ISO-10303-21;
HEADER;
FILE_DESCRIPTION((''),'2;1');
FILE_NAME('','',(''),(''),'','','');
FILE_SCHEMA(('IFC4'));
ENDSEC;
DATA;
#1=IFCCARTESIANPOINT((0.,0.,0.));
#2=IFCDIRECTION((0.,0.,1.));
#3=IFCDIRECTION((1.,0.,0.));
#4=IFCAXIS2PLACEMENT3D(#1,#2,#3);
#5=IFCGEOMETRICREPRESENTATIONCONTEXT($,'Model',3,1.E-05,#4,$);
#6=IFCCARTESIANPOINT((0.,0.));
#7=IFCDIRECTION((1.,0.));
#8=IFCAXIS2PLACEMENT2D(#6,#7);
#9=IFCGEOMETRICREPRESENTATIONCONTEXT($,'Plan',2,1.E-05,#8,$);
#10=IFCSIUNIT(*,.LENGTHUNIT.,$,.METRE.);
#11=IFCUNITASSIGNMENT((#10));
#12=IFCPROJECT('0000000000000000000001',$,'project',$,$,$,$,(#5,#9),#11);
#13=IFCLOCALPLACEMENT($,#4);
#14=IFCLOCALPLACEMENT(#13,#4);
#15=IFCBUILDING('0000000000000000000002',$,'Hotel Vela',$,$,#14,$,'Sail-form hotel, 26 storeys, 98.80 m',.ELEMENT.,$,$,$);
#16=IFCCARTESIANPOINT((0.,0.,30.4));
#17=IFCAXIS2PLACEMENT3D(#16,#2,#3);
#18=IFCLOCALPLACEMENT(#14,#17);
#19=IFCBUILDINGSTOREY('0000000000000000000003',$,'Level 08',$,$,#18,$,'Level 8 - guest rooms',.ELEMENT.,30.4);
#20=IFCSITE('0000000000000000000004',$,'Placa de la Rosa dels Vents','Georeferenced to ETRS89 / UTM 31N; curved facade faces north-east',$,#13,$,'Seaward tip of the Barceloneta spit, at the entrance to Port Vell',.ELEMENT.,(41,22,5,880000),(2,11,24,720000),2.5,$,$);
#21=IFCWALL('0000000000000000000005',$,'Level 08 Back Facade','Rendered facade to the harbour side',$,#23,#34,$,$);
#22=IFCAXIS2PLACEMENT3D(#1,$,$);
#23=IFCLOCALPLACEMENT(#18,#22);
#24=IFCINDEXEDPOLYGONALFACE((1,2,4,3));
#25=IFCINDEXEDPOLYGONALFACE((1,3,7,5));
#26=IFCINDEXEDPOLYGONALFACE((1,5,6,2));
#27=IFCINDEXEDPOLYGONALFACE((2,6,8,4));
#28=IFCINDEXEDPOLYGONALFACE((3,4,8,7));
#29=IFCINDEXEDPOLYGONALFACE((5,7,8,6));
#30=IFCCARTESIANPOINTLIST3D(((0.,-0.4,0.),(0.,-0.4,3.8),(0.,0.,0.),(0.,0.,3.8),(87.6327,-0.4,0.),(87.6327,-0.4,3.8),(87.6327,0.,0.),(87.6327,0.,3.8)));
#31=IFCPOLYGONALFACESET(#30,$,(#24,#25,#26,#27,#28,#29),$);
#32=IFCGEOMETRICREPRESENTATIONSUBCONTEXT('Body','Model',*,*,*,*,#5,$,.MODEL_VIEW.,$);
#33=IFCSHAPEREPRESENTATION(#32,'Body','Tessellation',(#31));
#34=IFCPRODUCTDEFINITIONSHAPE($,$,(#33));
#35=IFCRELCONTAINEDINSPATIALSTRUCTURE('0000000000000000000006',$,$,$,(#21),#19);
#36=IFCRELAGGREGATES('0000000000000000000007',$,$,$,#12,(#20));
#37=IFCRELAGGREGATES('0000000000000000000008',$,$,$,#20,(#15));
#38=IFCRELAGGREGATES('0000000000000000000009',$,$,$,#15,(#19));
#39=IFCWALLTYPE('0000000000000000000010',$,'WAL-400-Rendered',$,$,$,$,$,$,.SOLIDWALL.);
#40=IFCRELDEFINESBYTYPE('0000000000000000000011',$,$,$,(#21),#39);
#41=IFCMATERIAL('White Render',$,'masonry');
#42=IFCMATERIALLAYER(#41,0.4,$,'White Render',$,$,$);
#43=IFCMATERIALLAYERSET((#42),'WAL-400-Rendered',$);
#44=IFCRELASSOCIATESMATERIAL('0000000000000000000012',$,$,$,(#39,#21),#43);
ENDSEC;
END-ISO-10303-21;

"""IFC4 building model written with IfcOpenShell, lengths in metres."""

from ifc_helpers import new_model, si_unit, frame, origin_with_axes, origin_2d_with_axis, place, context, subcontext, project, spatial, line, indexed_curve, outline, extrude, material, layer, layer_set, layer_usage, type_object, element, save


model = new_model("IFC4")

# Units and contexts
model_context = context("Model", 3, precision=1e-05, world=origin_with_axes())
plan_context = context("Plan", 2, precision=1e-05, world=origin_2d_with_axis())
body_context = subcontext(model_context, "Body", "Model", "MODEL_VIEW")
ifc_project = project(units=[si_unit("LENGTHUNIT", "METRE")], contexts=[model_context, plan_context])

# Site, building, storey
site_placement = place(None, origin_with_axes())
site = spatial("IfcSite", under=ifc_project, at=site_placement, Name="Placa de la Rosa dels Vents", Description="Georeferenced to ETRS89 / UTM 31N; curved facade faces north-east", LongName="Seaward tip of the Barceloneta spit, at the entrance to Port Vell", CompositionType="ELEMENT", RefLatitude=(41, 22, 5, 880000), RefLongitude=(2, 11, 24, 720000), RefElevation=2.5)
building_placement = place(site_placement, origin_with_axes())
building = spatial("IfcBuilding", under=site, at=building_placement, Name="Hotel Vela", LongName="Sail-form hotel, 26 storeys, 98.80 m", CompositionType="ELEMENT")
storey_placement = place(building_placement, frame((0.0, 0.0, 30.4), z_axis=(0.0, 0.0, 1.0), x_axis=(1.0, 0.0, 0.0)))
storey = spatial("IfcBuildingStorey", under=building, at=storey_placement, Name="Level 08", LongName="Level 8 - guest rooms", CompositionType="ELEMENT", Elevation=30.4)

# Wall
ifc_material_1 = material(Name="White Render", Category="masonry")
ifc_layer_1 = layer(ifc_material_1, 0.4, Name="White Render")
ifc_layer_set_1 = layer_set([ifc_layer_1], Name="WAL-400-Rendered")
ifc_layer_usage_1 = layer_usage(ifc_layer_set_1, "AXIS2", "POSITIVE", 0.0)
wall_type = type_object("IfcWallType", Name="WAL-400-Rendered", PredefinedType="SOLIDWALL", material=ifc_layer_set_1)
wall_placement = place(storey_placement, frame((0.0, -0.4, 0.0), z_axis=(0.0, 0.0, 1.0), x_axis=(1.0, 0.0, 0.0)))
element("IfcWall", 1, at=wall_placement, inside=storey, type_object=wall_type, material=ifc_layer_usage_1, Name="Level 08 Back Facade", Description="Rendered facade to the harbour side", context=body_context, shape_type="SweptSolid", body=[
    extrude(outline(indexed_curve([(0.0, 0.0), (87.6327, 0.0), (87.6327, 0.4), (0.0, 0.4)], segments=[line(1, 2, 3, 4, 1)])), origin_with_axes(), (0.0, 0.0, 1.0), 3.8),
])

save(model, "model.ifc")
